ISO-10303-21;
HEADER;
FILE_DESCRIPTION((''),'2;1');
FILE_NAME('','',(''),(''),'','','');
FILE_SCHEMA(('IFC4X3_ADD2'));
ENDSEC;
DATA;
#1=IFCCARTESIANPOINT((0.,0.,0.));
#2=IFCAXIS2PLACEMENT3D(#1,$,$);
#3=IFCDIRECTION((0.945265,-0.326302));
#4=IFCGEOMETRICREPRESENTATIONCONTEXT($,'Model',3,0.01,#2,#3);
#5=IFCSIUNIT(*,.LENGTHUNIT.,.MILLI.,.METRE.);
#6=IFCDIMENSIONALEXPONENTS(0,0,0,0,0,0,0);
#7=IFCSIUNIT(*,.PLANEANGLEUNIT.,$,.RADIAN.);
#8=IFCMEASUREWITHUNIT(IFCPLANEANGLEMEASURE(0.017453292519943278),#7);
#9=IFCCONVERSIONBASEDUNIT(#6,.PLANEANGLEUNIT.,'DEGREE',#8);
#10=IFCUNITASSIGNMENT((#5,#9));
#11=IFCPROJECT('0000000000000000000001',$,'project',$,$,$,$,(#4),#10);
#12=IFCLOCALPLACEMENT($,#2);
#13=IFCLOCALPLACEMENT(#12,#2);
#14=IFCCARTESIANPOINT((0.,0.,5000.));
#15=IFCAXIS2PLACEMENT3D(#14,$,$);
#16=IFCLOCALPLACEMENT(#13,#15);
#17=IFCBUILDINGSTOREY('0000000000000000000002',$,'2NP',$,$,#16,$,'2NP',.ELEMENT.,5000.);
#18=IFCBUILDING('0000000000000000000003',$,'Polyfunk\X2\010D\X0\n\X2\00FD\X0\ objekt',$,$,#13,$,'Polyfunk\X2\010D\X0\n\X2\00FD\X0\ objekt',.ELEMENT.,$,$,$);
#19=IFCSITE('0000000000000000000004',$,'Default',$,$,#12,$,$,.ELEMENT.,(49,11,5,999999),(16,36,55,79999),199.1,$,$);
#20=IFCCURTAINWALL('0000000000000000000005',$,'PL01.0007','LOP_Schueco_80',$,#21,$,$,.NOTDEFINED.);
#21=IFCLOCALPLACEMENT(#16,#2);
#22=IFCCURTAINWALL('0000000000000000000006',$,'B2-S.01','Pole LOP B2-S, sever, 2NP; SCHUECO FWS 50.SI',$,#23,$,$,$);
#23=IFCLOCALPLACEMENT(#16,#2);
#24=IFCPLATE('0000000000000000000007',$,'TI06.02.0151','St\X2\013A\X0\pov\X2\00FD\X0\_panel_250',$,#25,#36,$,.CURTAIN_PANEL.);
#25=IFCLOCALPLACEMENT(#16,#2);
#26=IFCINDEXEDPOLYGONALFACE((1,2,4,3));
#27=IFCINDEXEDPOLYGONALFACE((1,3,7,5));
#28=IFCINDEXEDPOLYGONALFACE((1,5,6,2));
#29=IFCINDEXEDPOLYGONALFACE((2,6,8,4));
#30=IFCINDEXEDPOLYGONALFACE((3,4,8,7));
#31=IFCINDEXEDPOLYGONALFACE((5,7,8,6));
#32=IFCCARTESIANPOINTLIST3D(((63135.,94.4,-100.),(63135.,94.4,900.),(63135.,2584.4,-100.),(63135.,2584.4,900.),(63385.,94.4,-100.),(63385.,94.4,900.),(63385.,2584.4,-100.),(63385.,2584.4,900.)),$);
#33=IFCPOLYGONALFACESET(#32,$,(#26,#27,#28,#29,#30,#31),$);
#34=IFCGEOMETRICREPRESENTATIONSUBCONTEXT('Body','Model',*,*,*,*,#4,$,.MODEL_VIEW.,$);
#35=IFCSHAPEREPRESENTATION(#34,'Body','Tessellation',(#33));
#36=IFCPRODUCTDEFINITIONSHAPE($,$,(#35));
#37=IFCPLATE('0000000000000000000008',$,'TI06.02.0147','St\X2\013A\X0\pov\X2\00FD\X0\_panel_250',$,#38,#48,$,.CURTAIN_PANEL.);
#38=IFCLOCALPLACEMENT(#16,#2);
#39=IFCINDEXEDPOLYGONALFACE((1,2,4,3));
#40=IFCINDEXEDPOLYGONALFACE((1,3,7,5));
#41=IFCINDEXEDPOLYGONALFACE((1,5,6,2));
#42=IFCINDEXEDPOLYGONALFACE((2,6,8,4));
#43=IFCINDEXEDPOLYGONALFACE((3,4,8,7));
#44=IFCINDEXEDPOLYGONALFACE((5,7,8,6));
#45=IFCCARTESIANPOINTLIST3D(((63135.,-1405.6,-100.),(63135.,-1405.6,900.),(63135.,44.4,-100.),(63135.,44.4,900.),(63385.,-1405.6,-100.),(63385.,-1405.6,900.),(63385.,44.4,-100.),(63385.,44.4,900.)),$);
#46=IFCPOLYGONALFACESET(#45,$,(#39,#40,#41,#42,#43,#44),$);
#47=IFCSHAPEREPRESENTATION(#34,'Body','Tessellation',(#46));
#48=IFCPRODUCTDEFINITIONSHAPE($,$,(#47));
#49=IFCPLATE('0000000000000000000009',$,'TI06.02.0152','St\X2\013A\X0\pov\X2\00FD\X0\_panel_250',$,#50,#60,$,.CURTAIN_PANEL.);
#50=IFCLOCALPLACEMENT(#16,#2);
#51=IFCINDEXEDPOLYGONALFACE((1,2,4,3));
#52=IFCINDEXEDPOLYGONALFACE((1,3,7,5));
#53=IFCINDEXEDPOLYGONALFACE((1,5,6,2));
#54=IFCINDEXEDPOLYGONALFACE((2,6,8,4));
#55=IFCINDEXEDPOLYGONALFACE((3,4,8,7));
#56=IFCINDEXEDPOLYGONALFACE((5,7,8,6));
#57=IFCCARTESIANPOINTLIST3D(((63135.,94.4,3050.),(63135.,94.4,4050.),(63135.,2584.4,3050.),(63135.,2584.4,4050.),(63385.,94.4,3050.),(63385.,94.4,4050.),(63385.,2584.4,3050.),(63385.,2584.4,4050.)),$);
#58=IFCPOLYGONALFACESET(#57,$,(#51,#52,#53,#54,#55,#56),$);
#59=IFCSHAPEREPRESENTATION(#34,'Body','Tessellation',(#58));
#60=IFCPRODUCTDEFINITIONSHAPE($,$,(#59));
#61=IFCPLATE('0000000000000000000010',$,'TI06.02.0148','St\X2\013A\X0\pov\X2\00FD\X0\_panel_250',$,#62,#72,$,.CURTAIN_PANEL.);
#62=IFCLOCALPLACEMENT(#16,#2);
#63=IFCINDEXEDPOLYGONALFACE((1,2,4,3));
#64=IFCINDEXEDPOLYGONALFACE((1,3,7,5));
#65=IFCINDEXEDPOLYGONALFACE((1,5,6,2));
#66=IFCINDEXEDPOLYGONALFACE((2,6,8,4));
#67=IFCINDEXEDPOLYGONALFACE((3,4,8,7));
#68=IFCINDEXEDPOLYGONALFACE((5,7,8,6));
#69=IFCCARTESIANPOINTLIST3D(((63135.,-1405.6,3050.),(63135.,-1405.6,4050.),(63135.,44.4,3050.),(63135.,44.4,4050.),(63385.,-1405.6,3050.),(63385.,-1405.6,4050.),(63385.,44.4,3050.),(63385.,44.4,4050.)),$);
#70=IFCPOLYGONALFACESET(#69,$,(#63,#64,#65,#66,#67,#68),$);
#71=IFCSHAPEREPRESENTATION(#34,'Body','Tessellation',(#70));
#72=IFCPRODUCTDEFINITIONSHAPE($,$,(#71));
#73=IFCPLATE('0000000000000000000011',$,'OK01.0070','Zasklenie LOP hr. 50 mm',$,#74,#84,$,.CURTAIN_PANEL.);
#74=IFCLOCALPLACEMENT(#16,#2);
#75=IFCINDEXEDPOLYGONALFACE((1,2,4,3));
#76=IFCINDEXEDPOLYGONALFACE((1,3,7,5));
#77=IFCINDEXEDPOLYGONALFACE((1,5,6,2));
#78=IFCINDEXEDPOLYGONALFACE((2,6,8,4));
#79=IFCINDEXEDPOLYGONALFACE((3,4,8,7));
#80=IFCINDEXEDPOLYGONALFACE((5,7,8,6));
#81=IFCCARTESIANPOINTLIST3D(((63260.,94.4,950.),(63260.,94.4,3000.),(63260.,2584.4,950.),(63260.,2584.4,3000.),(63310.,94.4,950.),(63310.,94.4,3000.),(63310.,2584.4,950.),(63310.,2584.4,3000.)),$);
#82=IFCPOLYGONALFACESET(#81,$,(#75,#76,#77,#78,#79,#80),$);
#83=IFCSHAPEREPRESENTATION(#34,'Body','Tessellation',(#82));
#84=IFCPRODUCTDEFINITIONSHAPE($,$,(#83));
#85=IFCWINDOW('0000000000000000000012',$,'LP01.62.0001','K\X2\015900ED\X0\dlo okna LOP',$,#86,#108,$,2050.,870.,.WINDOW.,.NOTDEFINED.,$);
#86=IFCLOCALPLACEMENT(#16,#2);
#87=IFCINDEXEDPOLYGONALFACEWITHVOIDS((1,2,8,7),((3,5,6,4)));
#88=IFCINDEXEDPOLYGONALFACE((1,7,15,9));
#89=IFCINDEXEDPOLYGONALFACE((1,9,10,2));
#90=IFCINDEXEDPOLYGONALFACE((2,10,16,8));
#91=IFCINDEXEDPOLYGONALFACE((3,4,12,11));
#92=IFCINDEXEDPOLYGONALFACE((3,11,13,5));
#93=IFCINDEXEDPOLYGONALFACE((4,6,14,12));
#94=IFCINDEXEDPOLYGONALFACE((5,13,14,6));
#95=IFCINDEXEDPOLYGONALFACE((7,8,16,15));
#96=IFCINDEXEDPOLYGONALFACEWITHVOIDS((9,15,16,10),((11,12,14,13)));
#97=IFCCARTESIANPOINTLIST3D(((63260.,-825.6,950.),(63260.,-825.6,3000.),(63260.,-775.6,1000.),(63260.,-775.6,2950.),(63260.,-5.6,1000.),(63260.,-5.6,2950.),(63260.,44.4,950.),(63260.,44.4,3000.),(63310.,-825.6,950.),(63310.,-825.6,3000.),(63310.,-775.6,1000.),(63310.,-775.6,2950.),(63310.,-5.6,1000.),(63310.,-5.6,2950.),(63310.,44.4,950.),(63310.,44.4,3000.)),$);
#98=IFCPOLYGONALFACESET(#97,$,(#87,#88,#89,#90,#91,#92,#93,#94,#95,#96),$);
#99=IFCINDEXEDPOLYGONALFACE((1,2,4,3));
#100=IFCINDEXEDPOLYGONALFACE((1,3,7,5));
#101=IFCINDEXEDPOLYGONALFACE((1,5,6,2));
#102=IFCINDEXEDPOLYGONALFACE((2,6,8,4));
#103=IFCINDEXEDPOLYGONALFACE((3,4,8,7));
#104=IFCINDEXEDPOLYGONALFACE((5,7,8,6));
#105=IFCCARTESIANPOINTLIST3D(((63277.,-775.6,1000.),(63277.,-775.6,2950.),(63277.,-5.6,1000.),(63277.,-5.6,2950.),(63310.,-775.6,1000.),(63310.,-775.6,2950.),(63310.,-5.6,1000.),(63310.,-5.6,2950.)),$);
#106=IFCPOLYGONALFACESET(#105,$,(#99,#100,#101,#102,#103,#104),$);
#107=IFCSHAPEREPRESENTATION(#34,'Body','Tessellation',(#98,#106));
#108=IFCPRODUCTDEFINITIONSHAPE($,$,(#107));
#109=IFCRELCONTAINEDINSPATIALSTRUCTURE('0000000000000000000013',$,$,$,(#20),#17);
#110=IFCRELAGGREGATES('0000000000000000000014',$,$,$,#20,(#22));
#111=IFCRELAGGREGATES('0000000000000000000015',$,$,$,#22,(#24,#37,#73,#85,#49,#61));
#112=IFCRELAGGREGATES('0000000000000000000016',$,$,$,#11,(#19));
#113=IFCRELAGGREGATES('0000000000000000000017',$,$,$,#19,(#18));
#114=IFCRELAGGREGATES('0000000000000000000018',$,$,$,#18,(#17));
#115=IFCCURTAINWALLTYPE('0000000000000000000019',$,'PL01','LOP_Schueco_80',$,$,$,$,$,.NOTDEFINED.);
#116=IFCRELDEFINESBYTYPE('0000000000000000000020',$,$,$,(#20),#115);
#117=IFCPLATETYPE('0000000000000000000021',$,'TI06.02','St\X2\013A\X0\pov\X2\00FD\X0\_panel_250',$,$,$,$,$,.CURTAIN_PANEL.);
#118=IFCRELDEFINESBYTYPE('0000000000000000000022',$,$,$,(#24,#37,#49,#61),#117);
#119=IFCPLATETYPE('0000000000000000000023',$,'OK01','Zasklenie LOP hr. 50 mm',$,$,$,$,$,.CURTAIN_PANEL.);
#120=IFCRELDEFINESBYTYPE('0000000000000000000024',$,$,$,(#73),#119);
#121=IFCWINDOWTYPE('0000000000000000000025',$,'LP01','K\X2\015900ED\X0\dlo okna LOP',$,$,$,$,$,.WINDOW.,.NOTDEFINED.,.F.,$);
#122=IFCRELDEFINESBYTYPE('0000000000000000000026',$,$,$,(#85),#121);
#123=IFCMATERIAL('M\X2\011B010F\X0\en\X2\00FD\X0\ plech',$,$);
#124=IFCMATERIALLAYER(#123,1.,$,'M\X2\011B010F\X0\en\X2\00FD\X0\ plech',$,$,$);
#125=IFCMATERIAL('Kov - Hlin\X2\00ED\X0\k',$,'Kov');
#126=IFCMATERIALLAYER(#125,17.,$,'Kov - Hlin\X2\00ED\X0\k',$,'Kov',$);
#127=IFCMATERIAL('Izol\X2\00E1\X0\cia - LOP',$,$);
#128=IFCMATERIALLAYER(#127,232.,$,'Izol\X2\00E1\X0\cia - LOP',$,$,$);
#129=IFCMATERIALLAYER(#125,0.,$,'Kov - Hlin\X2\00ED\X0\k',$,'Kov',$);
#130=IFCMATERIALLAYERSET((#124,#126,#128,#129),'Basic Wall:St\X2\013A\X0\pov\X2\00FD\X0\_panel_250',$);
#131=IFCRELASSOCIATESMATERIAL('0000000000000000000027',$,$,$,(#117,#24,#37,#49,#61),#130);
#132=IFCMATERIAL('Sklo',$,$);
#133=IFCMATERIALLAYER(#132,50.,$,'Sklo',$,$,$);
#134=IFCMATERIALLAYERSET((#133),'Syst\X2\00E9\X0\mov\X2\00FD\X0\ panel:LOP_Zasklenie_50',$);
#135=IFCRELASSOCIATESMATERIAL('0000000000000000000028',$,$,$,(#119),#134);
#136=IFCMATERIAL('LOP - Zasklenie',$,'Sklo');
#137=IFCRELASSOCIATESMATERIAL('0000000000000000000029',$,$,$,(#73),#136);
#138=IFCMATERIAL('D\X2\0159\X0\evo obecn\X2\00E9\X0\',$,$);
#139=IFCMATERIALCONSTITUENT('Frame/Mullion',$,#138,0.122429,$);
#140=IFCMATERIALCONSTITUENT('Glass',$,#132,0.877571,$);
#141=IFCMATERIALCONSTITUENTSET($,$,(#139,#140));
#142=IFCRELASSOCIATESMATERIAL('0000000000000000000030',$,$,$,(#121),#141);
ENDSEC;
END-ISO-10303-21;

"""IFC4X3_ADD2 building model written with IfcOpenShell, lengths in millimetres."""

from ifc_helpers import new_model, entity, si_unit, converted_unit, direction, frame, frame_2d, origin, origin_2d_with_axis, place, context, subcontext, project, spatial, polyline, rectangle, outline, extrude, source, transform, mapped, material, layer, layer_set, layer_usage, constituent, constituent_set, type_object, type_shapes, element, aggregate, save


model = new_model("IFC4X3_ADD2")

# Units and contexts
model_context = context("Model", 3, precision=0.01, world=origin(), true_north=direction((0.945265, -0.326302)))
body_context = subcontext(model_context, "Body", "Model", "MODEL_VIEW")
ifc_project = project(units=[si_unit("LENGTHUNIT", "METRE", prefix="MILLI"), converted_unit("PLANEANGLEUNIT", "DEGREE", entity("IfcPlaneAngleMeasure", 0.017453292519943278), si_unit("PLANEANGLEUNIT", "RADIAN"), dimensions=[0, 0, 0, 0, 0, 0, 0])], contexts=[model_context])

# Site, building, storey
site_placement = place(None, origin())
site = spatial("IfcSite", under=ifc_project, at=site_placement, Name="Default", CompositionType="ELEMENT", RefLatitude=(49, 11, 5, 999999), RefLongitude=(16, 36, 55, 79999), RefElevation=199.1)
building_placement = place(site_placement, origin())
building = spatial("IfcBuilding", under=site, at=building_placement, Name="Polyfunkčný objekt", LongName="Polyfunkčný objekt", CompositionType="ELEMENT")
storey_placement = place(building_placement, frame((0.0, 0.0, 5000.0)))
storey = spatial("IfcBuildingStorey", under=building, at=storey_placement, Name="2NP", LongName="2NP", CompositionType="ELEMENT", Elevation=5000.0)

# Curtain walls, plates, window
curtain_wall_type = type_object("IfcCurtainWallType", Name="PL01", Description="LOP_Schueco_80", PredefinedType="NOTDEFINED")
curtain_wall_1_placement = place(storey_placement, frame((0.0, 0.0, -5000.0)))
curtain_wall_1 = element("IfcCurtainWall", 1, at=curtain_wall_1_placement, inside=storey, type_object=curtain_wall_type, Name="PL01.0007", Description="LOP_Schueco_80", PredefinedType="NOTDEFINED")
curtain_wall_2 = element("IfcCurtainWall", 2, Name="B2-S.01", Description="Pole LOP B2-S, sever, 2NP; SCHUECO FWS 50.SI")
aggregate(curtain_wall_1, [curtain_wall_2])
ifc_material_1 = material(Name="Měďený plech")
ifc_layer_1 = layer(ifc_material_1, 1.0, Name="Měďený plech")
ifc_material_2 = material(Name="Kov - Hliník", Category="Kov")
ifc_layer_2 = layer(ifc_material_2, 17.0, Name="Kov - Hliník", Category="Kov")
ifc_material_3 = material(Name="Izolácia - LOP")
ifc_layer_3 = layer(ifc_material_3, 232.0, Name="Izolácia - LOP")
ifc_layer_4 = layer(ifc_material_2, 0.0, Name="Kov - Hliník", Category="Kov")
ifc_layer_set_1 = layer_set([ifc_layer_1, ifc_layer_2, ifc_layer_3, ifc_layer_4], Name="Basic Wall:Stĺpový_panel_250")
ifc_layer_usage_1 = layer_usage(ifc_layer_set_1, "AXIS2", "NEGATIVE", 125.0)
plate_type_1 = type_object("IfcPlateType", Name="TI06.02", Description="Stĺpový_panel_250", PredefinedType="CURTAIN_PANEL", material=ifc_layer_set_1)
plate_1_placement = place(storey_placement, frame((63260.0, 2584.4, -100.0), z_axis=(0.0, 0.0, 1.0), x_axis=(0.0, -1.0, 0.0)))
plate_1 = element("IfcPlate", 3, at=plate_1_placement, type_object=plate_type_1, material=ifc_layer_usage_1, Name="TI06.02.0151", Description="Stĺpový_panel_250", PredefinedType="CURTAIN_PANEL", context=body_context, shape_type="SweptSolid", body=[
    extrude(rectangle(XDim=250.0, YDim=2490.0, at=frame_2d((0.0, 0.0), x_axis=(1.0, 0.0))), frame((1245.0, 0.0, 0.0), z_axis=(0.0, 0.0, 1.0), x_axis=(0.0, 1.0, 0.0)), (0.0, 0.0, 1.0), 1000.0),
])
ifc_layer_usage_2 = layer_usage(ifc_layer_set_1, "AXIS2", "NEGATIVE", 125.0)
plate_2_placement = place(storey_placement, frame((63260.0, 44.4, -100.0), z_axis=(0.0, 0.0, 1.0), x_axis=(0.0, -1.0, 0.0)))
plate_2 = element("IfcPlate", 4, at=plate_2_placement, type_object=plate_type_1, material=ifc_layer_usage_2, Name="TI06.02.0147", Description="Stĺpový_panel_250", PredefinedType="CURTAIN_PANEL", context=body_context, shape_type="SweptSolid", body=[
    extrude(rectangle(XDim=250.0, YDim=1450.0, at=frame_2d((0.0, 0.0), x_axis=(1.0, 0.0))), frame((725.0, 0.0, 0.0), z_axis=(0.0, 0.0, 1.0), x_axis=(0.0, 1.0, 0.0)), (0.0, 0.0, 1.0), 1000.0),
])
ifc_layer_usage_3 = layer_usage(ifc_layer_set_1, "AXIS2", "NEGATIVE", 125.0)
plate_3_placement = place(storey_placement, frame((63260.0, 2584.4, 3050.0), z_axis=(0.0, 0.0, 1.0), x_axis=(0.0, -1.0, 0.0)))
plate_3 = element("IfcPlate", 5, at=plate_3_placement, type_object=plate_type_1, material=ifc_layer_usage_3, Name="TI06.02.0152", Description="Stĺpový_panel_250", PredefinedType="CURTAIN_PANEL", context=body_context, shape_type="SweptSolid", body=[
    extrude(rectangle(XDim=250.0, YDim=2490.0, at=frame_2d((0.0, 0.0), x_axis=(1.0, 0.0))), frame((1245.0, 0.0, 0.0), z_axis=(0.0, 0.0, 1.0), x_axis=(0.0, 1.0, 0.0)), (0.0, 0.0, 1.0), 1000.0),
])
ifc_layer_usage_4 = layer_usage(ifc_layer_set_1, "AXIS2", "NEGATIVE", 125.0)
plate_4_placement = place(storey_placement, frame((63260.0, 44.4, 3050.0), z_axis=(0.0, 0.0, 1.0), x_axis=(0.0, -1.0, 0.0)))
plate_4 = element("IfcPlate", 6, at=plate_4_placement, type_object=plate_type_1, material=ifc_layer_usage_4, Name="TI06.02.0148", Description="Stĺpový_panel_250", PredefinedType="CURTAIN_PANEL", context=body_context, shape_type="SweptSolid", body=[
    extrude(rectangle(XDim=250.0, YDim=1450.0, at=frame_2d((0.0, 0.0), x_axis=(1.0, 0.0))), frame((725.0, 0.0, 0.0), z_axis=(0.0, 0.0, 1.0), x_axis=(0.0, 1.0, 0.0)), (0.0, 0.0, 1.0), 1000.0),
])
ifc_material_4 = material(Name="LOP - Zasklenie", Category="Sklo")
ifc_material_5 = material(Name="Sklo")
ifc_layer_5 = layer(ifc_material_5, 50.0, Name="Sklo")
ifc_layer_set_2 = layer_set([ifc_layer_5], Name="Systémový panel:LOP_Zasklenie_50")
plate_type_2 = type_object("IfcPlateType", Name="OK01", Description="Zasklenie LOP hr. 50 mm", PredefinedType="CURTAIN_PANEL", material=ifc_layer_set_2)
shared_shape_1 = source(origin(), body_context, "Body", "SweptSolid", [
    extrude(rectangle(XDim=50.0, YDim=2490.0, at=origin_2d_with_axis()), frame((0.0, 25.0, 0.0), z_axis=(0.0, 0.0, 1.0), x_axis=(0.0, 1.0, 0.0)), (0.0, 0.0, 1.0), 2050.0),
])
type_shapes(plate_type_2, [shared_shape_1])
plate_5_placement = place(curtain_wall_1_placement, frame((63260.0, 1339.4, 5950.0), z_axis=(0.0, 0.0, 1.0), x_axis=(0.0, -1.0, 0.0)))
plate_5 = element("IfcPlate", 7, at=plate_5_placement, type_object=plate_type_2, material=ifc_material_4, Name="OK01.0070", Description="Zasklenie LOP hr. 50 mm", PredefinedType="CURTAIN_PANEL", context=body_context, shape_type="MappedRepresentation", body=[
    mapped(shared_shape_1, transform((0.0, 0.0, 0.0), scale=1.0)),
])
ifc_material_6 = material(Name="Dřevo obecné")
ifc_constituent_1 = constituent(ifc_material_6, Name="Frame/Mullion", fraction=0.122429)
ifc_constituent_2 = constituent(ifc_material_5, Name="Glass", fraction=0.877571)
ifc_constituent_set = constituent_set(constituents=[ifc_constituent_1, ifc_constituent_2])
window_type = type_object("IfcWindowType", Name="LP01", Description="Křídlo okna LOP", ParameterTakesPrecedence=False, PartitioningType="NOTDEFINED", PredefinedType="WINDOW", material=ifc_constituent_set)
shared_shape_2 = source(origin(), body_context, "Body", "SweptSolid", [
    extrude(outline(polyline([(-1025.0, -435.0), (1025.0, -435.0), (1025.0, 435.0), (-1025.0, 435.0), (-1025.0, -435.0)]), holes=[polyline([(-975.0, -385.0), (-975.0, 385.0), (975.0, 385.0), (975.0, -385.0), (-975.0, -385.0)])]), frame((0.0, 0.0, 1025.0), z_axis=(0.0, 1.0, 0.0), x_axis=(0.0, 0.0, -1.0)), (0.0, 0.0, 1.0), 50.0),
    extrude(rectangle(XDim=33.0, YDim=770.0, at=origin_2d_with_axis()), frame((0.0, 33.5, 50.0), z_axis=(0.0, 0.0, 1.0), x_axis=(0.0, -1.0, 0.0)), (0.0, 0.0, 1.0), 1950.0),
])
type_shapes(window_type, [shared_shape_2])
window_placement = place(curtain_wall_1_placement, frame((63260.0, -390.6, 5950.0), z_axis=(0.0, 0.0, 1.0), x_axis=(0.0, -1.0, 0.0)))
window = element("IfcWindow", 8, at=window_placement, type_object=window_type, Name="LP01.62.0001", Description="Křídlo okna LOP", OverallHeight=2050.0, OverallWidth=870.0, PartitioningType="NOTDEFINED", PredefinedType="WINDOW", context=body_context, shape_type="MappedRepresentation", body=[
    mapped(shared_shape_2, transform((0.0, 0.0, 0.0), scale=1.0)),
])
aggregate(curtain_wall_2, [plate_1, plate_2, plate_5, window, plate_3, plate_4])

save(model, "model.ifc")
